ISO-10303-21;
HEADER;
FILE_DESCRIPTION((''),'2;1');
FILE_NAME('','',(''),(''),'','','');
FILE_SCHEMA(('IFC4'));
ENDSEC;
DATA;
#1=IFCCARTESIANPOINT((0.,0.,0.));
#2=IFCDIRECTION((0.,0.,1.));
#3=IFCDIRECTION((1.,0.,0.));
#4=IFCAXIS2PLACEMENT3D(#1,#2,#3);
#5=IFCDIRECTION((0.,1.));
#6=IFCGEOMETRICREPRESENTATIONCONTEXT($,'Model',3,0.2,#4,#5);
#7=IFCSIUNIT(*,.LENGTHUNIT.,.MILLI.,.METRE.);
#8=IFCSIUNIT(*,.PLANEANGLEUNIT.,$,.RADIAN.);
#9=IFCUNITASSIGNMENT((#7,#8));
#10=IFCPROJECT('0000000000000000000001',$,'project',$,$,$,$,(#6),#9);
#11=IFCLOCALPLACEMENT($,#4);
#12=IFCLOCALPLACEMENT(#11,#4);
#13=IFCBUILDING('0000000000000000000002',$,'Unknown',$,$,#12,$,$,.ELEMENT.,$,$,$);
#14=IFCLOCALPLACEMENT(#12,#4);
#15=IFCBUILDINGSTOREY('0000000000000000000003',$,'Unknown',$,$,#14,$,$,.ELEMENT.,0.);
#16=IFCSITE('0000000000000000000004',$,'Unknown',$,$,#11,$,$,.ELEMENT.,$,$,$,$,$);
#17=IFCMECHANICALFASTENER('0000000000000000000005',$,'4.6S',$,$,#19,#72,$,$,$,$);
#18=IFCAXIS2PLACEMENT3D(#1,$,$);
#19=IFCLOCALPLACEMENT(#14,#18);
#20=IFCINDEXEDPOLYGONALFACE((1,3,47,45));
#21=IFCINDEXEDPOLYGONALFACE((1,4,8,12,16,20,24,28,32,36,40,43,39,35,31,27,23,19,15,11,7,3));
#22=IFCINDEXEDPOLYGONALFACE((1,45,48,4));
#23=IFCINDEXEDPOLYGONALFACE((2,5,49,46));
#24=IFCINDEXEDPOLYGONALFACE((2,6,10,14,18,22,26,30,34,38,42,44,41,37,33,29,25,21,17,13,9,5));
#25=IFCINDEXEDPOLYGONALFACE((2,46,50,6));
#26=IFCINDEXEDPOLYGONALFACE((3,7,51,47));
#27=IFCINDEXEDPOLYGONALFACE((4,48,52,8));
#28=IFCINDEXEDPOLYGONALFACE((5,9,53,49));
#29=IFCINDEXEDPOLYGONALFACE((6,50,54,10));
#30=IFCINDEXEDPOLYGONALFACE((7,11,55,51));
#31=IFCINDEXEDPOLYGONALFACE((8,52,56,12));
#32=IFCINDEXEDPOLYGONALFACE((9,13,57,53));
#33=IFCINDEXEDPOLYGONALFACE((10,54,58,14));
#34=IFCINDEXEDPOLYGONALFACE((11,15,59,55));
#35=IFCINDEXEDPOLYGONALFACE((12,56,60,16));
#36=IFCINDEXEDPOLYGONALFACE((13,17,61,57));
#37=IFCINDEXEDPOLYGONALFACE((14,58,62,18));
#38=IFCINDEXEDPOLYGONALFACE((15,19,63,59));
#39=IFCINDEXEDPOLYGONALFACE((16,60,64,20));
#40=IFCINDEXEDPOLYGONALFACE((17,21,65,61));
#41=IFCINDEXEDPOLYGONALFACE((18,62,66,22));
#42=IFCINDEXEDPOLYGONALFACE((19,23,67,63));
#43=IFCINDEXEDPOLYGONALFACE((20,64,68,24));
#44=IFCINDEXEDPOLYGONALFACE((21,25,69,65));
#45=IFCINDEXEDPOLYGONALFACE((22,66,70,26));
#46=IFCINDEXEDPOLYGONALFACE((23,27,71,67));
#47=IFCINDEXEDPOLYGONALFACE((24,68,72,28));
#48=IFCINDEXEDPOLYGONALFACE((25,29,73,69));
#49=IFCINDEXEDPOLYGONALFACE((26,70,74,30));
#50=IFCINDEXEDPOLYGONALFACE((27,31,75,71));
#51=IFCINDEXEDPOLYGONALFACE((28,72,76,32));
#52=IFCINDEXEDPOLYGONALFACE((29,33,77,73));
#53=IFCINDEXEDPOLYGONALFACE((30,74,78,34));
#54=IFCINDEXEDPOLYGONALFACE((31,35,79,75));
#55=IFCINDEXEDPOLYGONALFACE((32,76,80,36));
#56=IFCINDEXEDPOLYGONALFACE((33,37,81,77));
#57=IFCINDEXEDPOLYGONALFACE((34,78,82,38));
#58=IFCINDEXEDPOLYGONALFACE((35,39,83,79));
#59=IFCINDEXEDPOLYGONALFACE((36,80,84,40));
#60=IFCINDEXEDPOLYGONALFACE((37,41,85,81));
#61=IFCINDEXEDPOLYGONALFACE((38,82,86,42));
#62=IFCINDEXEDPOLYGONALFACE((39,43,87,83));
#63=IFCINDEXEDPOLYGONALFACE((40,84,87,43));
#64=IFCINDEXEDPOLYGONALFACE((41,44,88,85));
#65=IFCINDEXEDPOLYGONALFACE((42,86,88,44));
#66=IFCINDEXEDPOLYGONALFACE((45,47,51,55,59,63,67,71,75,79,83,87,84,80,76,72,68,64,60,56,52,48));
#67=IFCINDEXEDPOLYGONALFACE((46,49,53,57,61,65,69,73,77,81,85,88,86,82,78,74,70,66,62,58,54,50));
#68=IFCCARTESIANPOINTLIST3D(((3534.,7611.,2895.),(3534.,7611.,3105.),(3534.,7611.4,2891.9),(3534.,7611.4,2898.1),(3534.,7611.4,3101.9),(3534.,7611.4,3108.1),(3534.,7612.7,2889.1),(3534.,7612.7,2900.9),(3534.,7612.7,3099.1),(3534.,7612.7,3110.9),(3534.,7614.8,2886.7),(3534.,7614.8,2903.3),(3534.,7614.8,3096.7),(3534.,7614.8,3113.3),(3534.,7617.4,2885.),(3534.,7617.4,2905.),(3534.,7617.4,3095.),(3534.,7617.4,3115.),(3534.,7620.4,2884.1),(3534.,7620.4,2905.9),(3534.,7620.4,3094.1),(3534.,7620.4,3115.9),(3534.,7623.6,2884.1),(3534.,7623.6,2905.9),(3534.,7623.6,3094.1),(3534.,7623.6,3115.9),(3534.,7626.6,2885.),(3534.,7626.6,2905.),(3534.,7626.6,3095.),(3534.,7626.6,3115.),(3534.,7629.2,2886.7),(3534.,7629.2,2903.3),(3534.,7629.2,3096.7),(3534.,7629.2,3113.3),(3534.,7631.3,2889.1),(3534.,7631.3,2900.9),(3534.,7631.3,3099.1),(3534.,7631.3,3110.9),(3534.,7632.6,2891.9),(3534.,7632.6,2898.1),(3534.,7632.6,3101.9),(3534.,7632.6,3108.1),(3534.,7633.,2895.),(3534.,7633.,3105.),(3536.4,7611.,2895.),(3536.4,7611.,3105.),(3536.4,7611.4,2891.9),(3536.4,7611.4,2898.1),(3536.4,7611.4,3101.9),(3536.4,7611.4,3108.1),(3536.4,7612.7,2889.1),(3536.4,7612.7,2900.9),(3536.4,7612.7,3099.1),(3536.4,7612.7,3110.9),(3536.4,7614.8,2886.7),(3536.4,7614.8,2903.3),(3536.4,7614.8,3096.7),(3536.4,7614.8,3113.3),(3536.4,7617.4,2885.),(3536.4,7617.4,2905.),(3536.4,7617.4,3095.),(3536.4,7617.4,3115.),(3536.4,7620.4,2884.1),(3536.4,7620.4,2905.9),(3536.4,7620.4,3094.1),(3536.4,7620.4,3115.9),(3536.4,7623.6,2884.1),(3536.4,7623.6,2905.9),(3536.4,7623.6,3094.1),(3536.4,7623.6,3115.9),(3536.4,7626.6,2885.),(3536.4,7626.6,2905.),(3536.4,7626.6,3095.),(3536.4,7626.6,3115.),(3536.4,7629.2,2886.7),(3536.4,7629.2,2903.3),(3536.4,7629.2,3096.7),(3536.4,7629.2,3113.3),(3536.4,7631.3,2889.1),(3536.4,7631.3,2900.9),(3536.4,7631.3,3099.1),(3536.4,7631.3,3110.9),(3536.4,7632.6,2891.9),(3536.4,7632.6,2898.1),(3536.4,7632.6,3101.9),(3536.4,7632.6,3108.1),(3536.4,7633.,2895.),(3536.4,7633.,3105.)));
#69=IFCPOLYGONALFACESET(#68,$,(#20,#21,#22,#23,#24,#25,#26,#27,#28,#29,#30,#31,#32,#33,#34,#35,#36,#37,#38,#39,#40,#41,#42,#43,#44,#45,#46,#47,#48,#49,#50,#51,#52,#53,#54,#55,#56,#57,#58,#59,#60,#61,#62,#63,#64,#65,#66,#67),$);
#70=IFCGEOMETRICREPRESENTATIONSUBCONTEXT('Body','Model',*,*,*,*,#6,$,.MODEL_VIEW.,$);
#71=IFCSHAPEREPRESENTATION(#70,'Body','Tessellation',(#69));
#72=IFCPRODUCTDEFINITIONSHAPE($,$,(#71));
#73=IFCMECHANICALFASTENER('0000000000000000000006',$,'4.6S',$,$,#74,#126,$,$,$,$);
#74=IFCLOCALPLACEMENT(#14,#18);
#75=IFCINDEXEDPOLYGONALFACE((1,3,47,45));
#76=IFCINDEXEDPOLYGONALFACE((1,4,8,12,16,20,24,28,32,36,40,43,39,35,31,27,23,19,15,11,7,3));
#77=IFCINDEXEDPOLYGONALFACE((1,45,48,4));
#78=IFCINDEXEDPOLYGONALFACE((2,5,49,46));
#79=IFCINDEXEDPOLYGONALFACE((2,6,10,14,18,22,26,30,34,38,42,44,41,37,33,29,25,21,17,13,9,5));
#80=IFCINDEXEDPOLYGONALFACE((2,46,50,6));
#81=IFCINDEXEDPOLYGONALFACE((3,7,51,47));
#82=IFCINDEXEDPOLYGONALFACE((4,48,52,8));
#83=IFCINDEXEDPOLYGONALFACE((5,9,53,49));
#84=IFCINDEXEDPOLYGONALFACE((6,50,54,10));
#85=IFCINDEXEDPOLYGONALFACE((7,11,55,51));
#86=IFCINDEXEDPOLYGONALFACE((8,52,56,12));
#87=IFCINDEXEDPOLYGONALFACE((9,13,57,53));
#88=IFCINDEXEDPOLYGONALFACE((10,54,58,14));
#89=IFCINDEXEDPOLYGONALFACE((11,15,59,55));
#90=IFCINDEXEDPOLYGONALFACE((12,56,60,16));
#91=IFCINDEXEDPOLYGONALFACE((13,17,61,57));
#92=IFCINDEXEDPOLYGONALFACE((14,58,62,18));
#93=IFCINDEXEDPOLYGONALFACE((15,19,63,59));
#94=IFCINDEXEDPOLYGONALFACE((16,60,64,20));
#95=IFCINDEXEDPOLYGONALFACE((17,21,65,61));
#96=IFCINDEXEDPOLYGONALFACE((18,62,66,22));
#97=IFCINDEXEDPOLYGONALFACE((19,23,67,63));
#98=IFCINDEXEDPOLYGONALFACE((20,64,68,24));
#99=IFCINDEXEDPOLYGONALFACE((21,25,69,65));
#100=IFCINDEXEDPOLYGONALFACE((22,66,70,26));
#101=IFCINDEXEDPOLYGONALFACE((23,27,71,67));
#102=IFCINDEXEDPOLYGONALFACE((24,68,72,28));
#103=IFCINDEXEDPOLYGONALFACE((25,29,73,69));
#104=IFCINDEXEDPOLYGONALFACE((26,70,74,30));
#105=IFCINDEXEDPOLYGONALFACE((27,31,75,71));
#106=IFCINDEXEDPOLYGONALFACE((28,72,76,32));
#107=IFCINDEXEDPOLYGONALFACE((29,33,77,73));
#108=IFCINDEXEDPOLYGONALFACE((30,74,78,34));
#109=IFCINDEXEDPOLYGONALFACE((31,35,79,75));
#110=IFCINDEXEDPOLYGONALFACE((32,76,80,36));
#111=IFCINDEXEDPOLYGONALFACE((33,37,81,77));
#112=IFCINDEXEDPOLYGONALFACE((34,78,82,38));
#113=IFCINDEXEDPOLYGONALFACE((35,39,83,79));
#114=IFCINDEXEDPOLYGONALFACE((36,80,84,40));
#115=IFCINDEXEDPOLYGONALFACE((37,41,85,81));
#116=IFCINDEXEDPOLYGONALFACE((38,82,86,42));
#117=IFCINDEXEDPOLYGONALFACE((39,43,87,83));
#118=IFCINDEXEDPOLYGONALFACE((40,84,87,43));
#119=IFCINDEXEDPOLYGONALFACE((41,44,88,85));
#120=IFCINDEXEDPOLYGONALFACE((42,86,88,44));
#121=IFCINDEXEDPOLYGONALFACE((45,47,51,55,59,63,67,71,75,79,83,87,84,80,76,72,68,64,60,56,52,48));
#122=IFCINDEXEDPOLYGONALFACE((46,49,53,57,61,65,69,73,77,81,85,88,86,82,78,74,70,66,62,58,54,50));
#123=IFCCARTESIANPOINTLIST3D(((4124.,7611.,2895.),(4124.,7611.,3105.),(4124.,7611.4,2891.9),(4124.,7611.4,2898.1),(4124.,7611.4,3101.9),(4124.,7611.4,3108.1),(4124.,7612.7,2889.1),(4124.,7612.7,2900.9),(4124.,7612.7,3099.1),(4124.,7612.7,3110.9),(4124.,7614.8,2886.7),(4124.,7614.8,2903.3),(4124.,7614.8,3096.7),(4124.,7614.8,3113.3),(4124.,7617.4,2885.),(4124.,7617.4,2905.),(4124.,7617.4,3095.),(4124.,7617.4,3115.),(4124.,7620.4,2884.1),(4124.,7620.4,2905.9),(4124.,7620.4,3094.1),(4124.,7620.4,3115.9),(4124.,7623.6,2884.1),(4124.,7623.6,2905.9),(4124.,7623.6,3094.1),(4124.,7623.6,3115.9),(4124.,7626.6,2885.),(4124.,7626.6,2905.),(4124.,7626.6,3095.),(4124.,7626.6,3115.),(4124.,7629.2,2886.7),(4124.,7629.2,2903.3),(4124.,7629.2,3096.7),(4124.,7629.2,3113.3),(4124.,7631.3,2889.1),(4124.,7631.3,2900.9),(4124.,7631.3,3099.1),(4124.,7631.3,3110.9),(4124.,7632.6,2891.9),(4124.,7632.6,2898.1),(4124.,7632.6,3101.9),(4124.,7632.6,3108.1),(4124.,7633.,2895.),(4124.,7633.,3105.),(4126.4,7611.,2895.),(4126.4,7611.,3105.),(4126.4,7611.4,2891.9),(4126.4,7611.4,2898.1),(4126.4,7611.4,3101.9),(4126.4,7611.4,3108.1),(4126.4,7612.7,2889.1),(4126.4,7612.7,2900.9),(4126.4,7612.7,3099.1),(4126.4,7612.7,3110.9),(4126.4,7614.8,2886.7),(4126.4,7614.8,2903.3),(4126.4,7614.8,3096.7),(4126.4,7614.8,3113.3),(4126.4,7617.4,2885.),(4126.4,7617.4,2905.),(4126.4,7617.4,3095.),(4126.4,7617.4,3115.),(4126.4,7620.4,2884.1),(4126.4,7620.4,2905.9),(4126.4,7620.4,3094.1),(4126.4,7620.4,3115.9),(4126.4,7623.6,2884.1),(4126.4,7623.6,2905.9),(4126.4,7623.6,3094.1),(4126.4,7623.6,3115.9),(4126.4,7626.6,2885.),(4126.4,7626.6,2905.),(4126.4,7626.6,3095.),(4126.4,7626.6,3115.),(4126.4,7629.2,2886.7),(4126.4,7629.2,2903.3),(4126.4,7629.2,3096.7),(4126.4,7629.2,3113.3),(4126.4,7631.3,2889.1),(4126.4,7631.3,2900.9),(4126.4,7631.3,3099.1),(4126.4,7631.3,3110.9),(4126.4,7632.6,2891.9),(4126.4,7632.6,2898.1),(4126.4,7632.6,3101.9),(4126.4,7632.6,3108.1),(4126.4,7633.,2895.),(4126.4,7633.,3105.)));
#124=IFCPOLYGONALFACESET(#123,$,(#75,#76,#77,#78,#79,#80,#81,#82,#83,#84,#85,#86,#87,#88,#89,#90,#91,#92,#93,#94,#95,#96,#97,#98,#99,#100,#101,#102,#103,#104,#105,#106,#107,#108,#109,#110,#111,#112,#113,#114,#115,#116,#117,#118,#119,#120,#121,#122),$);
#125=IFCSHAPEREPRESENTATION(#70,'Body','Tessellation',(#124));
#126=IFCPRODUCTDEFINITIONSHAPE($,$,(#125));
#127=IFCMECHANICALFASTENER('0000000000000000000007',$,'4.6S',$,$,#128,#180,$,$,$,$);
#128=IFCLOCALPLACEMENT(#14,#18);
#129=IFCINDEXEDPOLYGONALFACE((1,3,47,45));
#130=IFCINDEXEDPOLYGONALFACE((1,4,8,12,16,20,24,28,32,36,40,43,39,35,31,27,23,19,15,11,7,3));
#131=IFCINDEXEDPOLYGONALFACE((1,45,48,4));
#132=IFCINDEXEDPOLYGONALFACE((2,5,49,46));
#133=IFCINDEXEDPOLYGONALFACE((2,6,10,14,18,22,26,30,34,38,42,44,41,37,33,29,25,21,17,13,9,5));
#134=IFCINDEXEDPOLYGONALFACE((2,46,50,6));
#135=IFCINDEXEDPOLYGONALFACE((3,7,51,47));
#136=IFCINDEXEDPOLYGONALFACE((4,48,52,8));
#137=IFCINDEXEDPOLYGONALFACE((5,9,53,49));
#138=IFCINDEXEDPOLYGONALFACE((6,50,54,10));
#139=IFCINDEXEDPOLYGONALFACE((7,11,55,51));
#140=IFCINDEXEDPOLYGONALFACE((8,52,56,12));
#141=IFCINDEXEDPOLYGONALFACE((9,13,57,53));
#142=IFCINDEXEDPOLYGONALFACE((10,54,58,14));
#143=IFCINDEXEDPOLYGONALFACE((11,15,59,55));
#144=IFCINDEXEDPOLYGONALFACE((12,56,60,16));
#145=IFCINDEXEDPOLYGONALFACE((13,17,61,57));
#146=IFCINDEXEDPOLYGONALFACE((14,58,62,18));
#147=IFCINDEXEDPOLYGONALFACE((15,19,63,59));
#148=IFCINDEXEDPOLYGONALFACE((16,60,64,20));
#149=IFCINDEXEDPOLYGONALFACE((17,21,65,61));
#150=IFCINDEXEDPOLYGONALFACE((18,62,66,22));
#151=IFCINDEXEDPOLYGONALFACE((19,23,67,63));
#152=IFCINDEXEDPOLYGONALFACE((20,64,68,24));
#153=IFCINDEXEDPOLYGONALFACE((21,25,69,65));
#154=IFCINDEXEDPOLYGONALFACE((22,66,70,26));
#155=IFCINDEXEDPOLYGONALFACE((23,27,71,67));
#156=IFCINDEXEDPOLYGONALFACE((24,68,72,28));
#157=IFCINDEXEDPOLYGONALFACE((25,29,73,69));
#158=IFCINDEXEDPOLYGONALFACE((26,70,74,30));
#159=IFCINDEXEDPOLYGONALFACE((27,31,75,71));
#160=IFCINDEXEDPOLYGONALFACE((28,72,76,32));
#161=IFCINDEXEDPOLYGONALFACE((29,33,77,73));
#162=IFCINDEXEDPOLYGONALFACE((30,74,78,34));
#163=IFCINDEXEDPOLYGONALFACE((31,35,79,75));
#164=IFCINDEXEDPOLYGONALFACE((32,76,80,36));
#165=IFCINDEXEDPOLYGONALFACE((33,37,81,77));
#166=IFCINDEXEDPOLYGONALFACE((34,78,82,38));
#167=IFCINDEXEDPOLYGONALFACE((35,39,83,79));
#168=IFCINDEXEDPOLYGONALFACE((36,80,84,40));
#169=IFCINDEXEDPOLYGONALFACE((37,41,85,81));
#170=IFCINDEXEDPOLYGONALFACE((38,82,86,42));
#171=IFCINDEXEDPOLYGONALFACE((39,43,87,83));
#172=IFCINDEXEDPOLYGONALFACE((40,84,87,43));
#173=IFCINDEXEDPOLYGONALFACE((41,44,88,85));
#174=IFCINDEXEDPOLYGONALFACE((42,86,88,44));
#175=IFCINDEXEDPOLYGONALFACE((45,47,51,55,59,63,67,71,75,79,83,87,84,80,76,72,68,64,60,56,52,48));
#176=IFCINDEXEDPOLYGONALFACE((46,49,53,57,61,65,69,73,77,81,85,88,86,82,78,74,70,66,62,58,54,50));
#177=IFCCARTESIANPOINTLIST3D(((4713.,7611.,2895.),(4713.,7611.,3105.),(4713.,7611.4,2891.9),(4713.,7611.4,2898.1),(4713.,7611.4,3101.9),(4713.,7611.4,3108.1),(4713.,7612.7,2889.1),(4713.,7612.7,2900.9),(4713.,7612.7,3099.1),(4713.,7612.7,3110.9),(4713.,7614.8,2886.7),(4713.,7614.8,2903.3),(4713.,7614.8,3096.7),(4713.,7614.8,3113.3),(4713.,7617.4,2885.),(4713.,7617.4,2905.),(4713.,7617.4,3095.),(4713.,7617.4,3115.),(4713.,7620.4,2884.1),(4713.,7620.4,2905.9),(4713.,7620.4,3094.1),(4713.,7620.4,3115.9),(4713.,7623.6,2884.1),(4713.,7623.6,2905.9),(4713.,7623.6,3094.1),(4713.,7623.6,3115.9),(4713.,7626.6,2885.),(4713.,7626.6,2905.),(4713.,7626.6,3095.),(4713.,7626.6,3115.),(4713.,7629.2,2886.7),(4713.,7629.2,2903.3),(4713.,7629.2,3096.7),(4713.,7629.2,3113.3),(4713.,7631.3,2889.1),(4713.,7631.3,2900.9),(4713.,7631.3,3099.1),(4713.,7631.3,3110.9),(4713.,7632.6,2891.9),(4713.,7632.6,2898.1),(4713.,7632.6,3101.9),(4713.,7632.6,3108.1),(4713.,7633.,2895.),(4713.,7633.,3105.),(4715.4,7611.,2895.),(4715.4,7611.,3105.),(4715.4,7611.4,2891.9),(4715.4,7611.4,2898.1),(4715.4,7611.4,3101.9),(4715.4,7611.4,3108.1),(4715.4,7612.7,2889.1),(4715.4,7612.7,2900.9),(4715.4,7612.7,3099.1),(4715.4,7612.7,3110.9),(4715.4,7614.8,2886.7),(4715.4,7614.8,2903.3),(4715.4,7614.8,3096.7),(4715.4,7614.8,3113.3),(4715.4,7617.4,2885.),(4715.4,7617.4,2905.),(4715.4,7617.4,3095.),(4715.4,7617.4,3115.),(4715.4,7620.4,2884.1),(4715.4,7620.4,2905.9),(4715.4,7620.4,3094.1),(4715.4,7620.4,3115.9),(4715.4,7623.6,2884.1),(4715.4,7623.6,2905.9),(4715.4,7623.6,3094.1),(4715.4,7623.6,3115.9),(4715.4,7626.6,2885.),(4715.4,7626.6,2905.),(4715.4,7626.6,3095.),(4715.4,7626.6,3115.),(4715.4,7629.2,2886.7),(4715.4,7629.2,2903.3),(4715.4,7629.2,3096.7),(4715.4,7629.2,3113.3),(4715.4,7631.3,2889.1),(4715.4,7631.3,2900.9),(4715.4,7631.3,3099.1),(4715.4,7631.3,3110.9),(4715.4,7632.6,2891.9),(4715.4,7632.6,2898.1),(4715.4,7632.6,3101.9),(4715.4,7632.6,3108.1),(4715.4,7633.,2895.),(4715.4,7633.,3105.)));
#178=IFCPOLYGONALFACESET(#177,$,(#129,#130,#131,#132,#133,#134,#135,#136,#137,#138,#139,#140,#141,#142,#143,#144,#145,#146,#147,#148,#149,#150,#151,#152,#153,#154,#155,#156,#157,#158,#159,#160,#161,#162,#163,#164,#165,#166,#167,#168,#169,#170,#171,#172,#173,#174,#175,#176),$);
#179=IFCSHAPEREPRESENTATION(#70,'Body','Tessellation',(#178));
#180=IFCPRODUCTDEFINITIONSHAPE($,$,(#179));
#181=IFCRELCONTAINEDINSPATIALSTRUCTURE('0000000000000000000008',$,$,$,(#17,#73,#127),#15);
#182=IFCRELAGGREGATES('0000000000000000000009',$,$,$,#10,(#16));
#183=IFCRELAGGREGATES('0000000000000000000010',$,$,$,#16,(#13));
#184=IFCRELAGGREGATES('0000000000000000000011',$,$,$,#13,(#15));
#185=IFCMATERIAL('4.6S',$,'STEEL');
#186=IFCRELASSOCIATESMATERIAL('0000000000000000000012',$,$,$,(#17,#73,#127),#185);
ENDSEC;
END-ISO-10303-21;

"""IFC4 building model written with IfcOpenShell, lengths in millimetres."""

from ifc_helpers import new_model, si_unit, direction, frame, origin_with_axes, place, context, subcontext, project, spatial, arc, indexed_curve, outline, extrude, source, transform, mapped, material, element, save


model = new_model("IFC4")

# Units and contexts
model_context = context("Model", 3, precision=0.2, world=origin_with_axes(), true_north=direction((0.0, 1.0)))
body_context = subcontext(model_context, "Body", "Model", "MODEL_VIEW")
ifc_project = project(units=[si_unit("LENGTHUNIT", "METRE", prefix="MILLI"), si_unit("PLANEANGLEUNIT", "RADIAN")], contexts=[model_context])

# Site, building, storey
site_placement = place(None, origin_with_axes())
site = spatial("IfcSite", under=ifc_project, at=site_placement, Name="Unknown", CompositionType="ELEMENT")
building_placement = place(site_placement, origin_with_axes())
building = spatial("IfcBuilding", under=site, at=building_placement, Name="Unknown", CompositionType="ELEMENT")
storey_placement = place(building_placement, origin_with_axes())
storey = spatial("IfcBuildingStorey", under=building, at=storey_placement, Name="Unknown", CompositionType="ELEMENT", Elevation=0.0)

# Mechanical fasteners
ifc_material_1 = material(Name="4.6S", Category="STEEL")
shared_shape_1 = source(origin_with_axes(), body_context, "Body", "SweptSolid", [
    extrude(outline(indexed_curve([(11.0, 0.0), (0.0, 11.0), (-11.0, 0.0), (0.0, -11.0)], segments=[arc(1, 2, 3), arc(3, 4, 1)])), frame((0.0, 0.0, 1.2), z_axis=(0.0, 0.0, -1.0), x_axis=(0.0, 1.0, 0.0)), (0.0, 0.0, 1.0), 2.4),
])
for number, where, z_axis, x_axis, name in (
    (1, (3535.2, 7622.0, 2895.0), (-1.0, 0.0, 0.0), (0.0, 0.0, 1.0), "4.6S"),
    (2, (4125.2, 7622.0, 2895.0), (-1.0, 0.0, 0.0), (0.0, 0.0, 1.0), "4.6S"),
    (3, (4714.2, 7622.0, 2895.0), (-1.0, 0.0, 0.0), (0.0, 0.0, 1.0), "4.6S"),
):
    element("IfcMechanicalFastener", number, at=place(storey_placement, frame(where, z_axis=z_axis, x_axis=x_axis)), inside=storey, material=ifc_material_1, Name=name, context=body_context, shape_type="MappedRepresentation", body=[
        mapped(shared_shape_1, transform((0.0, 0.0, 0.0))),
        mapped(shared_shape_1, transform((210.0, 0.0, 0.0))),
    ])

save(model, "model.ifc")
